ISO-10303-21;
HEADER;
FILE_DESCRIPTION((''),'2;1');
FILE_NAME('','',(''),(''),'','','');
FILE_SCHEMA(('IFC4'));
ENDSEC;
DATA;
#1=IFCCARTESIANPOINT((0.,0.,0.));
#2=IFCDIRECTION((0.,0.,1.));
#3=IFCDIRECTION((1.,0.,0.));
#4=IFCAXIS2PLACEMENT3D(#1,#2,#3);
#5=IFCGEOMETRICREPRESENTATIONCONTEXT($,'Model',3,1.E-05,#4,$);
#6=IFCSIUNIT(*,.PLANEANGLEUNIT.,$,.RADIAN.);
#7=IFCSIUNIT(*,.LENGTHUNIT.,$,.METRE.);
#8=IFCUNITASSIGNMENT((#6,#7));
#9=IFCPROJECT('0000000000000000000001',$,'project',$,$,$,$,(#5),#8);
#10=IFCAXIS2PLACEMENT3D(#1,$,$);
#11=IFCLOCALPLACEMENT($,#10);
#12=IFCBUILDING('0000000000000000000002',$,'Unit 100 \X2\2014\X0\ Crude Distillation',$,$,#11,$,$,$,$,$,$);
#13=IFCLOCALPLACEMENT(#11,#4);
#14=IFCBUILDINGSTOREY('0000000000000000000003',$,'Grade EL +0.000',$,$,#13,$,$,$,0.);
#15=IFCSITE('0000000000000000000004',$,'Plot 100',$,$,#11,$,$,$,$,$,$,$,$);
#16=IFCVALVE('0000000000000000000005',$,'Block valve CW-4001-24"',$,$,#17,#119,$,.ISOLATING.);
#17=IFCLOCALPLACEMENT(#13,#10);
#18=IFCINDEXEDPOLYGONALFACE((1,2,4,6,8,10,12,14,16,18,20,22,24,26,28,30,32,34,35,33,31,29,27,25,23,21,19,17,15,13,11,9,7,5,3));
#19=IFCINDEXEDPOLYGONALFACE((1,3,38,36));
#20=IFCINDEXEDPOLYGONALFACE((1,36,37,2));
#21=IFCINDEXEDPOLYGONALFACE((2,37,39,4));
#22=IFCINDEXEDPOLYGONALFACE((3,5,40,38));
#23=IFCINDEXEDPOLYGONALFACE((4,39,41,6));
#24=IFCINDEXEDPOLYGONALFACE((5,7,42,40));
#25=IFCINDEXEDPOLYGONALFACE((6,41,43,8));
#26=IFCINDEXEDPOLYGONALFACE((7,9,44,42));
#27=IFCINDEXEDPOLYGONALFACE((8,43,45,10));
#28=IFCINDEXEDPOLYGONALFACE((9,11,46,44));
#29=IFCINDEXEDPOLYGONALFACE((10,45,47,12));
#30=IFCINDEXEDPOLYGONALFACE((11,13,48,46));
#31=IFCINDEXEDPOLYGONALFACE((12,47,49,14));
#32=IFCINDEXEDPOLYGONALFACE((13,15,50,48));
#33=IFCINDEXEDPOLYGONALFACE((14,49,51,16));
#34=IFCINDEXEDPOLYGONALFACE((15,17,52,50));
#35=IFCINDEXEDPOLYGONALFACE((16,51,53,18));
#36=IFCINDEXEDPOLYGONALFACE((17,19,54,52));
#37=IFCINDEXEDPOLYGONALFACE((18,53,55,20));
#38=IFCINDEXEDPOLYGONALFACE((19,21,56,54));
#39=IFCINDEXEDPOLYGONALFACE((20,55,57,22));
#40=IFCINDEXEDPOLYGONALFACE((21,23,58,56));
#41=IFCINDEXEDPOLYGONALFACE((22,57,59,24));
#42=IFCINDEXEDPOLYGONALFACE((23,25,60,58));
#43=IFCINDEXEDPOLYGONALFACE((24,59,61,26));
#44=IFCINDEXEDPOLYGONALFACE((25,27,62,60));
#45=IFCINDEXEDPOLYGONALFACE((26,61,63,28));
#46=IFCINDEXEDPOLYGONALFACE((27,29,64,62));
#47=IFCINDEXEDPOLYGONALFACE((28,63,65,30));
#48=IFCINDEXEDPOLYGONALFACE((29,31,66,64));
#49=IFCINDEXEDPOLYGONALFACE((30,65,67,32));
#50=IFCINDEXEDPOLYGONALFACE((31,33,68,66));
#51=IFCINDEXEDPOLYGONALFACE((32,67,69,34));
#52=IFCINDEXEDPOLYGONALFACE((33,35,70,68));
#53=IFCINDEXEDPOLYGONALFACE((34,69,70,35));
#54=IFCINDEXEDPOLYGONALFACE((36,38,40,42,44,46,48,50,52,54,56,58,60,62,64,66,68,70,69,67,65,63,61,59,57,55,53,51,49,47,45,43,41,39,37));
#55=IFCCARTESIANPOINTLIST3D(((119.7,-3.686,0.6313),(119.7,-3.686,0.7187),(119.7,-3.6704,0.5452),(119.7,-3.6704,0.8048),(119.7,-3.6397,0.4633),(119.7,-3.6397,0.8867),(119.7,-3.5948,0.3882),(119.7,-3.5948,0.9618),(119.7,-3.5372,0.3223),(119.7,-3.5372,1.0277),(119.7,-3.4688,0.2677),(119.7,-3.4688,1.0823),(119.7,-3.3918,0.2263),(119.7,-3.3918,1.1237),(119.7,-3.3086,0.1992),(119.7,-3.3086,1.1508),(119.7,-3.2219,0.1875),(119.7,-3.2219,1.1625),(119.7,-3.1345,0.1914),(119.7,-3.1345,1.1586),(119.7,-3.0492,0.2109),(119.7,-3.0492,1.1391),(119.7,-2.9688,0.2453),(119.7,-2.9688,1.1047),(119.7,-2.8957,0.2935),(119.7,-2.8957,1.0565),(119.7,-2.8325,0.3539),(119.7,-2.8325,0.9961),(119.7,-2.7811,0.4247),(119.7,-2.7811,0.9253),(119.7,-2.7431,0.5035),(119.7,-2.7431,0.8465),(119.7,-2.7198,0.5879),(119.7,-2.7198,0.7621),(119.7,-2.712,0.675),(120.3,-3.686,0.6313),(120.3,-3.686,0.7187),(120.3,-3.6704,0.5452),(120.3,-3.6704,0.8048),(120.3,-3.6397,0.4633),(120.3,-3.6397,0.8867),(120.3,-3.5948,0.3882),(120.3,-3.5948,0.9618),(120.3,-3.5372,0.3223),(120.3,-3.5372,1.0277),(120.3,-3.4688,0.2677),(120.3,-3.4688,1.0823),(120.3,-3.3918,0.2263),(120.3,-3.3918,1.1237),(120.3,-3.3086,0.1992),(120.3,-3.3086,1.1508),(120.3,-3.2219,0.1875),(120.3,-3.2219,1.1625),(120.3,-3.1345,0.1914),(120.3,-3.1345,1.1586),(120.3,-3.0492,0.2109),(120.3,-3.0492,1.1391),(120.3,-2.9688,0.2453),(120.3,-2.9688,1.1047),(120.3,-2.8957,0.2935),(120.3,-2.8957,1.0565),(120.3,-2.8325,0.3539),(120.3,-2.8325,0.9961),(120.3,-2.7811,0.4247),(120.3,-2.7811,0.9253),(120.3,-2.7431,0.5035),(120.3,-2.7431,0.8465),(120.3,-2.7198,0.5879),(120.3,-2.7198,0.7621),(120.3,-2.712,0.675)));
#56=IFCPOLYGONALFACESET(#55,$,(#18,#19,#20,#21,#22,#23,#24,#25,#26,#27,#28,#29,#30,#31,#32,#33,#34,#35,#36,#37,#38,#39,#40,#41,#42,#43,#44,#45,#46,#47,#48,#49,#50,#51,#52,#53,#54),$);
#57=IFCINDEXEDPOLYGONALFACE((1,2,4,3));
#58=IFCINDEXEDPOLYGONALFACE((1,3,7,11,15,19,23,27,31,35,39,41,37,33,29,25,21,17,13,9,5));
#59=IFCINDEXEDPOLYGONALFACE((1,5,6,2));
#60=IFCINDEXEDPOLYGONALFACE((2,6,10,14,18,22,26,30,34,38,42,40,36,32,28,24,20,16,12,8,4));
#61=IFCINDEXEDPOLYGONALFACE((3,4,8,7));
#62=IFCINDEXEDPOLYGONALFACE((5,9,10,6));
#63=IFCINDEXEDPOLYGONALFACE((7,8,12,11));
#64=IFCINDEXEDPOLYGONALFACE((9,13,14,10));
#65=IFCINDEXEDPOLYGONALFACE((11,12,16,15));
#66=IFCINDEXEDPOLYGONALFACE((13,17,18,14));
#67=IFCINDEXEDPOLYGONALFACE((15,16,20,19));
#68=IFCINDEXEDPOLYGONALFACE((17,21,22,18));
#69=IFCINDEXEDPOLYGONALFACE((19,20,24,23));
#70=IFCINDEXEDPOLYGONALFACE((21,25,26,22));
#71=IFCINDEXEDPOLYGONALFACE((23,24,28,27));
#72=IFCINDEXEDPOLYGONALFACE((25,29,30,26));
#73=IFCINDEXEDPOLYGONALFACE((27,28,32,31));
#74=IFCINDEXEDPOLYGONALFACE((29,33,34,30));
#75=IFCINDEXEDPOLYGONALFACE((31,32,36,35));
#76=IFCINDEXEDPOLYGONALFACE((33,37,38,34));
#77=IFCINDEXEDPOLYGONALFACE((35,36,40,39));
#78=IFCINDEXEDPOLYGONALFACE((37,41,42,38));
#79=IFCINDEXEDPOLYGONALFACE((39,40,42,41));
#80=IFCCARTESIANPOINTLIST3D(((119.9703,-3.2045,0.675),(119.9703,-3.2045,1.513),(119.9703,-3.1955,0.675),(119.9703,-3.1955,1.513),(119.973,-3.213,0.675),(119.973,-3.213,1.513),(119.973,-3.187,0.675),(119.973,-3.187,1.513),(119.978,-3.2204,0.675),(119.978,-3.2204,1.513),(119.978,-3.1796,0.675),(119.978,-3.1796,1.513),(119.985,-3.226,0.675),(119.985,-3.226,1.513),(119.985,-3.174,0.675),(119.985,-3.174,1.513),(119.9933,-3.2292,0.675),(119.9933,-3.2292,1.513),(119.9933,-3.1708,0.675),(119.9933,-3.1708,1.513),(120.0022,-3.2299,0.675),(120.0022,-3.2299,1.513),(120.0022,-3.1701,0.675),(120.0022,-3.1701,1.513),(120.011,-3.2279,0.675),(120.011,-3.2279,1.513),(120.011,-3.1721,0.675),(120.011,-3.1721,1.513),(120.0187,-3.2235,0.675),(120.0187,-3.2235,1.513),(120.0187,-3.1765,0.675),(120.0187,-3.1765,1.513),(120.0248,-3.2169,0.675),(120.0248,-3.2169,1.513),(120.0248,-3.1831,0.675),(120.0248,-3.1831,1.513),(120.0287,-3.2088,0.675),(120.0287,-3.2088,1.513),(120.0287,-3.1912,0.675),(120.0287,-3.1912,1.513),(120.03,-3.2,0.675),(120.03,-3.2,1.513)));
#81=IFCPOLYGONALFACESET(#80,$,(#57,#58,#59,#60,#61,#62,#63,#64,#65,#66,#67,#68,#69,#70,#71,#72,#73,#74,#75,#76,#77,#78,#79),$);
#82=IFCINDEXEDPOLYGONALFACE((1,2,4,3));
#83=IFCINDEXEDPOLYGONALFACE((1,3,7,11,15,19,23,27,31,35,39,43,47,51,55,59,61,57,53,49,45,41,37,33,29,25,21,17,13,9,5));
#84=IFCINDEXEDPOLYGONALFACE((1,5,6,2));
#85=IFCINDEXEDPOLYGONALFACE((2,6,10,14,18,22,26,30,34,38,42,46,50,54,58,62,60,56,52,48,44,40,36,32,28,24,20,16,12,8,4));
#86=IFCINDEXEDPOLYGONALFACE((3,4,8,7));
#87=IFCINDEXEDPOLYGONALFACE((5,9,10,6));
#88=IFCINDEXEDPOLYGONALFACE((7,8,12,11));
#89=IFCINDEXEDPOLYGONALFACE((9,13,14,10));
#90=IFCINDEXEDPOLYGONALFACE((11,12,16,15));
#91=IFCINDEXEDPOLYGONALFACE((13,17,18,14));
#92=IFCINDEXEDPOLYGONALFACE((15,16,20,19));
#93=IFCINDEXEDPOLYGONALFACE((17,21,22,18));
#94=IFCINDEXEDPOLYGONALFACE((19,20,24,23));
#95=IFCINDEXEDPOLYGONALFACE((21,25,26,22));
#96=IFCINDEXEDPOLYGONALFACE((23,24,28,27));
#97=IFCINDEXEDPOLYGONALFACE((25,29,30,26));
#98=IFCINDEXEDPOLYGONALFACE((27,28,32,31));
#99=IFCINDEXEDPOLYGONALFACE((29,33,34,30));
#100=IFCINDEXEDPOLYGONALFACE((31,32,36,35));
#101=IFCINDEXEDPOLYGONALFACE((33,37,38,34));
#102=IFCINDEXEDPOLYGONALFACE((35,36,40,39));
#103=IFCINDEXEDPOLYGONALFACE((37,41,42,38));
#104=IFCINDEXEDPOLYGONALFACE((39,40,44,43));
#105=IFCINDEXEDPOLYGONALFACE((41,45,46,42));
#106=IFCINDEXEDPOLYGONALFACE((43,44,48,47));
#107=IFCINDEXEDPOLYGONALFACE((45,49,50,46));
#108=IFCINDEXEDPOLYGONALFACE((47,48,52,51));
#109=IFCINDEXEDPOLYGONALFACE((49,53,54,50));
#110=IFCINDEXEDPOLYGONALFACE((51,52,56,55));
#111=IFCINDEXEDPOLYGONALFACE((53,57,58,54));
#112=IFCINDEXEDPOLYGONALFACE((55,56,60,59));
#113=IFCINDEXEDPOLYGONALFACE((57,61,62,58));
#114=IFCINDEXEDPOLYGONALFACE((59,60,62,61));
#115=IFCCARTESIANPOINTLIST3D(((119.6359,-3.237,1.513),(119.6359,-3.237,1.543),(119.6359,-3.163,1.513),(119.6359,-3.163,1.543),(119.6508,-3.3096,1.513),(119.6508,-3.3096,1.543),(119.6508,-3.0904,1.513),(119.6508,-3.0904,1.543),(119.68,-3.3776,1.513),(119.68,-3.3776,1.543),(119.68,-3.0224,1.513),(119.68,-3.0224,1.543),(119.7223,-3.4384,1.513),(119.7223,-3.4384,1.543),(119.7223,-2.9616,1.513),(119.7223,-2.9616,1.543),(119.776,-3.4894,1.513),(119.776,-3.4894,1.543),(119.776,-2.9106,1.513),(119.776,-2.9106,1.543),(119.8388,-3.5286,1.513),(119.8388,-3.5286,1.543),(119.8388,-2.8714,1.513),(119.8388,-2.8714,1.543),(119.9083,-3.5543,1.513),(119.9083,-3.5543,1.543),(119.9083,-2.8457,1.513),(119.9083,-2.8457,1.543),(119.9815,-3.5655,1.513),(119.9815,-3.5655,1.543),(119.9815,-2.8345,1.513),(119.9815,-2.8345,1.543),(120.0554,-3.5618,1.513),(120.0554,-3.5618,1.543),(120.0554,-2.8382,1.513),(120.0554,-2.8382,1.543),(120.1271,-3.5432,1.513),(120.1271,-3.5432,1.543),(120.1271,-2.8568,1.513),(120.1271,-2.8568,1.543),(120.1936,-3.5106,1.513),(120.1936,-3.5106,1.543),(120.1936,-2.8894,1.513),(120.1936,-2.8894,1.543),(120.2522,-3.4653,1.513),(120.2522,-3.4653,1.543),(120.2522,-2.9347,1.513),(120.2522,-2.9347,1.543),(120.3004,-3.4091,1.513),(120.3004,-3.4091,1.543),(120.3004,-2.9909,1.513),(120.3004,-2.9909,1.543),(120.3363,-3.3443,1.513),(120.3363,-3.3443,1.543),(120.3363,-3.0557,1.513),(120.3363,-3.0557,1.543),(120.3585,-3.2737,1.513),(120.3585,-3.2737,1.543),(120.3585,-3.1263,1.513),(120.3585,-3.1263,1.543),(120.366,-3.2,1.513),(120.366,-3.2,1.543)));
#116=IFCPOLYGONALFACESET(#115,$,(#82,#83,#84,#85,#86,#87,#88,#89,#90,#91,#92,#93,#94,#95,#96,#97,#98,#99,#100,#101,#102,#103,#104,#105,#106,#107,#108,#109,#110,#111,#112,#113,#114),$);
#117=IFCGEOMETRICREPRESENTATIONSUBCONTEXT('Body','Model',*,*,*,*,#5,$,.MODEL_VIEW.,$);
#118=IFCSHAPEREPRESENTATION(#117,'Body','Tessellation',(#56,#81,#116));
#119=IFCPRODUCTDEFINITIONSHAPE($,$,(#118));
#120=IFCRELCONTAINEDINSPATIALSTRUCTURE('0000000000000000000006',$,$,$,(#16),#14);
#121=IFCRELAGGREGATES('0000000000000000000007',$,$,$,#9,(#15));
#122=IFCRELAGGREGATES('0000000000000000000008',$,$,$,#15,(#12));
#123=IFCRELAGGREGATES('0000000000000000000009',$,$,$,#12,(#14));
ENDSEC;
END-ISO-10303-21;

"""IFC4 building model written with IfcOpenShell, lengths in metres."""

from ifc_helpers import new_model, si_unit, frame, origin, origin_with_axes, origin_2d, place, context, subcontext, project, spatial, circle, extrude, element, save


model = new_model("IFC4")

# Units and contexts
model_context = context("Model", 3, precision=1e-05, world=origin_with_axes())
body_context = subcontext(model_context, "Body", "Model", "MODEL_VIEW")
ifc_project = project(units=[si_unit("PLANEANGLEUNIT", "RADIAN"), si_unit("LENGTHUNIT", "METRE")], contexts=[model_context])

# Site, building, storey
placement = place(None, origin())
site = spatial("IfcSite", under=ifc_project, at=placement, Name="Plot 100")
building = spatial("IfcBuilding", under=site, at=placement, Name="Unit 100 — Crude Distillation")
storey_placement = place(placement, origin_with_axes())
storey = spatial("IfcBuildingStorey", under=building, at=storey_placement, Name="Grade EL +0.000", Elevation=0.0)

# Valve
valve_1_placement = place(storey_placement, origin_with_axes())
element("IfcValve", 1, at=valve_1_placement, inside=storey, Name="Block valve CW-4001-24\"", PredefinedType="ISOLATING", context=body_context, shape_type="SweptSolid", body=[
    extrude(circle(Radius=0.488, at=origin_2d()), frame((119.7, -3.2, 0.675), z_axis=(1.0, 0.0, 0.0), x_axis=(0.0, 1.0, 0.0)), (0.0, 0.0, 1.0), 0.6),
    extrude(circle(Radius=0.03, at=origin_2d()), frame((120.0, -3.2, 0.675), z_axis=(0.0, 0.0, 1.0), x_axis=(1.0, 0.0, 0.0)), (0.0, 0.0, 1.0), 0.838),
    extrude(circle(Radius=0.366, at=origin_2d()), frame((120.0, -3.2, 1.513), z_axis=(0.0, 0.0, 1.0), x_axis=(1.0, 0.0, 0.0)), (0.0, 0.0, 1.0), 0.03),
])

save(model, "model.ifc")
